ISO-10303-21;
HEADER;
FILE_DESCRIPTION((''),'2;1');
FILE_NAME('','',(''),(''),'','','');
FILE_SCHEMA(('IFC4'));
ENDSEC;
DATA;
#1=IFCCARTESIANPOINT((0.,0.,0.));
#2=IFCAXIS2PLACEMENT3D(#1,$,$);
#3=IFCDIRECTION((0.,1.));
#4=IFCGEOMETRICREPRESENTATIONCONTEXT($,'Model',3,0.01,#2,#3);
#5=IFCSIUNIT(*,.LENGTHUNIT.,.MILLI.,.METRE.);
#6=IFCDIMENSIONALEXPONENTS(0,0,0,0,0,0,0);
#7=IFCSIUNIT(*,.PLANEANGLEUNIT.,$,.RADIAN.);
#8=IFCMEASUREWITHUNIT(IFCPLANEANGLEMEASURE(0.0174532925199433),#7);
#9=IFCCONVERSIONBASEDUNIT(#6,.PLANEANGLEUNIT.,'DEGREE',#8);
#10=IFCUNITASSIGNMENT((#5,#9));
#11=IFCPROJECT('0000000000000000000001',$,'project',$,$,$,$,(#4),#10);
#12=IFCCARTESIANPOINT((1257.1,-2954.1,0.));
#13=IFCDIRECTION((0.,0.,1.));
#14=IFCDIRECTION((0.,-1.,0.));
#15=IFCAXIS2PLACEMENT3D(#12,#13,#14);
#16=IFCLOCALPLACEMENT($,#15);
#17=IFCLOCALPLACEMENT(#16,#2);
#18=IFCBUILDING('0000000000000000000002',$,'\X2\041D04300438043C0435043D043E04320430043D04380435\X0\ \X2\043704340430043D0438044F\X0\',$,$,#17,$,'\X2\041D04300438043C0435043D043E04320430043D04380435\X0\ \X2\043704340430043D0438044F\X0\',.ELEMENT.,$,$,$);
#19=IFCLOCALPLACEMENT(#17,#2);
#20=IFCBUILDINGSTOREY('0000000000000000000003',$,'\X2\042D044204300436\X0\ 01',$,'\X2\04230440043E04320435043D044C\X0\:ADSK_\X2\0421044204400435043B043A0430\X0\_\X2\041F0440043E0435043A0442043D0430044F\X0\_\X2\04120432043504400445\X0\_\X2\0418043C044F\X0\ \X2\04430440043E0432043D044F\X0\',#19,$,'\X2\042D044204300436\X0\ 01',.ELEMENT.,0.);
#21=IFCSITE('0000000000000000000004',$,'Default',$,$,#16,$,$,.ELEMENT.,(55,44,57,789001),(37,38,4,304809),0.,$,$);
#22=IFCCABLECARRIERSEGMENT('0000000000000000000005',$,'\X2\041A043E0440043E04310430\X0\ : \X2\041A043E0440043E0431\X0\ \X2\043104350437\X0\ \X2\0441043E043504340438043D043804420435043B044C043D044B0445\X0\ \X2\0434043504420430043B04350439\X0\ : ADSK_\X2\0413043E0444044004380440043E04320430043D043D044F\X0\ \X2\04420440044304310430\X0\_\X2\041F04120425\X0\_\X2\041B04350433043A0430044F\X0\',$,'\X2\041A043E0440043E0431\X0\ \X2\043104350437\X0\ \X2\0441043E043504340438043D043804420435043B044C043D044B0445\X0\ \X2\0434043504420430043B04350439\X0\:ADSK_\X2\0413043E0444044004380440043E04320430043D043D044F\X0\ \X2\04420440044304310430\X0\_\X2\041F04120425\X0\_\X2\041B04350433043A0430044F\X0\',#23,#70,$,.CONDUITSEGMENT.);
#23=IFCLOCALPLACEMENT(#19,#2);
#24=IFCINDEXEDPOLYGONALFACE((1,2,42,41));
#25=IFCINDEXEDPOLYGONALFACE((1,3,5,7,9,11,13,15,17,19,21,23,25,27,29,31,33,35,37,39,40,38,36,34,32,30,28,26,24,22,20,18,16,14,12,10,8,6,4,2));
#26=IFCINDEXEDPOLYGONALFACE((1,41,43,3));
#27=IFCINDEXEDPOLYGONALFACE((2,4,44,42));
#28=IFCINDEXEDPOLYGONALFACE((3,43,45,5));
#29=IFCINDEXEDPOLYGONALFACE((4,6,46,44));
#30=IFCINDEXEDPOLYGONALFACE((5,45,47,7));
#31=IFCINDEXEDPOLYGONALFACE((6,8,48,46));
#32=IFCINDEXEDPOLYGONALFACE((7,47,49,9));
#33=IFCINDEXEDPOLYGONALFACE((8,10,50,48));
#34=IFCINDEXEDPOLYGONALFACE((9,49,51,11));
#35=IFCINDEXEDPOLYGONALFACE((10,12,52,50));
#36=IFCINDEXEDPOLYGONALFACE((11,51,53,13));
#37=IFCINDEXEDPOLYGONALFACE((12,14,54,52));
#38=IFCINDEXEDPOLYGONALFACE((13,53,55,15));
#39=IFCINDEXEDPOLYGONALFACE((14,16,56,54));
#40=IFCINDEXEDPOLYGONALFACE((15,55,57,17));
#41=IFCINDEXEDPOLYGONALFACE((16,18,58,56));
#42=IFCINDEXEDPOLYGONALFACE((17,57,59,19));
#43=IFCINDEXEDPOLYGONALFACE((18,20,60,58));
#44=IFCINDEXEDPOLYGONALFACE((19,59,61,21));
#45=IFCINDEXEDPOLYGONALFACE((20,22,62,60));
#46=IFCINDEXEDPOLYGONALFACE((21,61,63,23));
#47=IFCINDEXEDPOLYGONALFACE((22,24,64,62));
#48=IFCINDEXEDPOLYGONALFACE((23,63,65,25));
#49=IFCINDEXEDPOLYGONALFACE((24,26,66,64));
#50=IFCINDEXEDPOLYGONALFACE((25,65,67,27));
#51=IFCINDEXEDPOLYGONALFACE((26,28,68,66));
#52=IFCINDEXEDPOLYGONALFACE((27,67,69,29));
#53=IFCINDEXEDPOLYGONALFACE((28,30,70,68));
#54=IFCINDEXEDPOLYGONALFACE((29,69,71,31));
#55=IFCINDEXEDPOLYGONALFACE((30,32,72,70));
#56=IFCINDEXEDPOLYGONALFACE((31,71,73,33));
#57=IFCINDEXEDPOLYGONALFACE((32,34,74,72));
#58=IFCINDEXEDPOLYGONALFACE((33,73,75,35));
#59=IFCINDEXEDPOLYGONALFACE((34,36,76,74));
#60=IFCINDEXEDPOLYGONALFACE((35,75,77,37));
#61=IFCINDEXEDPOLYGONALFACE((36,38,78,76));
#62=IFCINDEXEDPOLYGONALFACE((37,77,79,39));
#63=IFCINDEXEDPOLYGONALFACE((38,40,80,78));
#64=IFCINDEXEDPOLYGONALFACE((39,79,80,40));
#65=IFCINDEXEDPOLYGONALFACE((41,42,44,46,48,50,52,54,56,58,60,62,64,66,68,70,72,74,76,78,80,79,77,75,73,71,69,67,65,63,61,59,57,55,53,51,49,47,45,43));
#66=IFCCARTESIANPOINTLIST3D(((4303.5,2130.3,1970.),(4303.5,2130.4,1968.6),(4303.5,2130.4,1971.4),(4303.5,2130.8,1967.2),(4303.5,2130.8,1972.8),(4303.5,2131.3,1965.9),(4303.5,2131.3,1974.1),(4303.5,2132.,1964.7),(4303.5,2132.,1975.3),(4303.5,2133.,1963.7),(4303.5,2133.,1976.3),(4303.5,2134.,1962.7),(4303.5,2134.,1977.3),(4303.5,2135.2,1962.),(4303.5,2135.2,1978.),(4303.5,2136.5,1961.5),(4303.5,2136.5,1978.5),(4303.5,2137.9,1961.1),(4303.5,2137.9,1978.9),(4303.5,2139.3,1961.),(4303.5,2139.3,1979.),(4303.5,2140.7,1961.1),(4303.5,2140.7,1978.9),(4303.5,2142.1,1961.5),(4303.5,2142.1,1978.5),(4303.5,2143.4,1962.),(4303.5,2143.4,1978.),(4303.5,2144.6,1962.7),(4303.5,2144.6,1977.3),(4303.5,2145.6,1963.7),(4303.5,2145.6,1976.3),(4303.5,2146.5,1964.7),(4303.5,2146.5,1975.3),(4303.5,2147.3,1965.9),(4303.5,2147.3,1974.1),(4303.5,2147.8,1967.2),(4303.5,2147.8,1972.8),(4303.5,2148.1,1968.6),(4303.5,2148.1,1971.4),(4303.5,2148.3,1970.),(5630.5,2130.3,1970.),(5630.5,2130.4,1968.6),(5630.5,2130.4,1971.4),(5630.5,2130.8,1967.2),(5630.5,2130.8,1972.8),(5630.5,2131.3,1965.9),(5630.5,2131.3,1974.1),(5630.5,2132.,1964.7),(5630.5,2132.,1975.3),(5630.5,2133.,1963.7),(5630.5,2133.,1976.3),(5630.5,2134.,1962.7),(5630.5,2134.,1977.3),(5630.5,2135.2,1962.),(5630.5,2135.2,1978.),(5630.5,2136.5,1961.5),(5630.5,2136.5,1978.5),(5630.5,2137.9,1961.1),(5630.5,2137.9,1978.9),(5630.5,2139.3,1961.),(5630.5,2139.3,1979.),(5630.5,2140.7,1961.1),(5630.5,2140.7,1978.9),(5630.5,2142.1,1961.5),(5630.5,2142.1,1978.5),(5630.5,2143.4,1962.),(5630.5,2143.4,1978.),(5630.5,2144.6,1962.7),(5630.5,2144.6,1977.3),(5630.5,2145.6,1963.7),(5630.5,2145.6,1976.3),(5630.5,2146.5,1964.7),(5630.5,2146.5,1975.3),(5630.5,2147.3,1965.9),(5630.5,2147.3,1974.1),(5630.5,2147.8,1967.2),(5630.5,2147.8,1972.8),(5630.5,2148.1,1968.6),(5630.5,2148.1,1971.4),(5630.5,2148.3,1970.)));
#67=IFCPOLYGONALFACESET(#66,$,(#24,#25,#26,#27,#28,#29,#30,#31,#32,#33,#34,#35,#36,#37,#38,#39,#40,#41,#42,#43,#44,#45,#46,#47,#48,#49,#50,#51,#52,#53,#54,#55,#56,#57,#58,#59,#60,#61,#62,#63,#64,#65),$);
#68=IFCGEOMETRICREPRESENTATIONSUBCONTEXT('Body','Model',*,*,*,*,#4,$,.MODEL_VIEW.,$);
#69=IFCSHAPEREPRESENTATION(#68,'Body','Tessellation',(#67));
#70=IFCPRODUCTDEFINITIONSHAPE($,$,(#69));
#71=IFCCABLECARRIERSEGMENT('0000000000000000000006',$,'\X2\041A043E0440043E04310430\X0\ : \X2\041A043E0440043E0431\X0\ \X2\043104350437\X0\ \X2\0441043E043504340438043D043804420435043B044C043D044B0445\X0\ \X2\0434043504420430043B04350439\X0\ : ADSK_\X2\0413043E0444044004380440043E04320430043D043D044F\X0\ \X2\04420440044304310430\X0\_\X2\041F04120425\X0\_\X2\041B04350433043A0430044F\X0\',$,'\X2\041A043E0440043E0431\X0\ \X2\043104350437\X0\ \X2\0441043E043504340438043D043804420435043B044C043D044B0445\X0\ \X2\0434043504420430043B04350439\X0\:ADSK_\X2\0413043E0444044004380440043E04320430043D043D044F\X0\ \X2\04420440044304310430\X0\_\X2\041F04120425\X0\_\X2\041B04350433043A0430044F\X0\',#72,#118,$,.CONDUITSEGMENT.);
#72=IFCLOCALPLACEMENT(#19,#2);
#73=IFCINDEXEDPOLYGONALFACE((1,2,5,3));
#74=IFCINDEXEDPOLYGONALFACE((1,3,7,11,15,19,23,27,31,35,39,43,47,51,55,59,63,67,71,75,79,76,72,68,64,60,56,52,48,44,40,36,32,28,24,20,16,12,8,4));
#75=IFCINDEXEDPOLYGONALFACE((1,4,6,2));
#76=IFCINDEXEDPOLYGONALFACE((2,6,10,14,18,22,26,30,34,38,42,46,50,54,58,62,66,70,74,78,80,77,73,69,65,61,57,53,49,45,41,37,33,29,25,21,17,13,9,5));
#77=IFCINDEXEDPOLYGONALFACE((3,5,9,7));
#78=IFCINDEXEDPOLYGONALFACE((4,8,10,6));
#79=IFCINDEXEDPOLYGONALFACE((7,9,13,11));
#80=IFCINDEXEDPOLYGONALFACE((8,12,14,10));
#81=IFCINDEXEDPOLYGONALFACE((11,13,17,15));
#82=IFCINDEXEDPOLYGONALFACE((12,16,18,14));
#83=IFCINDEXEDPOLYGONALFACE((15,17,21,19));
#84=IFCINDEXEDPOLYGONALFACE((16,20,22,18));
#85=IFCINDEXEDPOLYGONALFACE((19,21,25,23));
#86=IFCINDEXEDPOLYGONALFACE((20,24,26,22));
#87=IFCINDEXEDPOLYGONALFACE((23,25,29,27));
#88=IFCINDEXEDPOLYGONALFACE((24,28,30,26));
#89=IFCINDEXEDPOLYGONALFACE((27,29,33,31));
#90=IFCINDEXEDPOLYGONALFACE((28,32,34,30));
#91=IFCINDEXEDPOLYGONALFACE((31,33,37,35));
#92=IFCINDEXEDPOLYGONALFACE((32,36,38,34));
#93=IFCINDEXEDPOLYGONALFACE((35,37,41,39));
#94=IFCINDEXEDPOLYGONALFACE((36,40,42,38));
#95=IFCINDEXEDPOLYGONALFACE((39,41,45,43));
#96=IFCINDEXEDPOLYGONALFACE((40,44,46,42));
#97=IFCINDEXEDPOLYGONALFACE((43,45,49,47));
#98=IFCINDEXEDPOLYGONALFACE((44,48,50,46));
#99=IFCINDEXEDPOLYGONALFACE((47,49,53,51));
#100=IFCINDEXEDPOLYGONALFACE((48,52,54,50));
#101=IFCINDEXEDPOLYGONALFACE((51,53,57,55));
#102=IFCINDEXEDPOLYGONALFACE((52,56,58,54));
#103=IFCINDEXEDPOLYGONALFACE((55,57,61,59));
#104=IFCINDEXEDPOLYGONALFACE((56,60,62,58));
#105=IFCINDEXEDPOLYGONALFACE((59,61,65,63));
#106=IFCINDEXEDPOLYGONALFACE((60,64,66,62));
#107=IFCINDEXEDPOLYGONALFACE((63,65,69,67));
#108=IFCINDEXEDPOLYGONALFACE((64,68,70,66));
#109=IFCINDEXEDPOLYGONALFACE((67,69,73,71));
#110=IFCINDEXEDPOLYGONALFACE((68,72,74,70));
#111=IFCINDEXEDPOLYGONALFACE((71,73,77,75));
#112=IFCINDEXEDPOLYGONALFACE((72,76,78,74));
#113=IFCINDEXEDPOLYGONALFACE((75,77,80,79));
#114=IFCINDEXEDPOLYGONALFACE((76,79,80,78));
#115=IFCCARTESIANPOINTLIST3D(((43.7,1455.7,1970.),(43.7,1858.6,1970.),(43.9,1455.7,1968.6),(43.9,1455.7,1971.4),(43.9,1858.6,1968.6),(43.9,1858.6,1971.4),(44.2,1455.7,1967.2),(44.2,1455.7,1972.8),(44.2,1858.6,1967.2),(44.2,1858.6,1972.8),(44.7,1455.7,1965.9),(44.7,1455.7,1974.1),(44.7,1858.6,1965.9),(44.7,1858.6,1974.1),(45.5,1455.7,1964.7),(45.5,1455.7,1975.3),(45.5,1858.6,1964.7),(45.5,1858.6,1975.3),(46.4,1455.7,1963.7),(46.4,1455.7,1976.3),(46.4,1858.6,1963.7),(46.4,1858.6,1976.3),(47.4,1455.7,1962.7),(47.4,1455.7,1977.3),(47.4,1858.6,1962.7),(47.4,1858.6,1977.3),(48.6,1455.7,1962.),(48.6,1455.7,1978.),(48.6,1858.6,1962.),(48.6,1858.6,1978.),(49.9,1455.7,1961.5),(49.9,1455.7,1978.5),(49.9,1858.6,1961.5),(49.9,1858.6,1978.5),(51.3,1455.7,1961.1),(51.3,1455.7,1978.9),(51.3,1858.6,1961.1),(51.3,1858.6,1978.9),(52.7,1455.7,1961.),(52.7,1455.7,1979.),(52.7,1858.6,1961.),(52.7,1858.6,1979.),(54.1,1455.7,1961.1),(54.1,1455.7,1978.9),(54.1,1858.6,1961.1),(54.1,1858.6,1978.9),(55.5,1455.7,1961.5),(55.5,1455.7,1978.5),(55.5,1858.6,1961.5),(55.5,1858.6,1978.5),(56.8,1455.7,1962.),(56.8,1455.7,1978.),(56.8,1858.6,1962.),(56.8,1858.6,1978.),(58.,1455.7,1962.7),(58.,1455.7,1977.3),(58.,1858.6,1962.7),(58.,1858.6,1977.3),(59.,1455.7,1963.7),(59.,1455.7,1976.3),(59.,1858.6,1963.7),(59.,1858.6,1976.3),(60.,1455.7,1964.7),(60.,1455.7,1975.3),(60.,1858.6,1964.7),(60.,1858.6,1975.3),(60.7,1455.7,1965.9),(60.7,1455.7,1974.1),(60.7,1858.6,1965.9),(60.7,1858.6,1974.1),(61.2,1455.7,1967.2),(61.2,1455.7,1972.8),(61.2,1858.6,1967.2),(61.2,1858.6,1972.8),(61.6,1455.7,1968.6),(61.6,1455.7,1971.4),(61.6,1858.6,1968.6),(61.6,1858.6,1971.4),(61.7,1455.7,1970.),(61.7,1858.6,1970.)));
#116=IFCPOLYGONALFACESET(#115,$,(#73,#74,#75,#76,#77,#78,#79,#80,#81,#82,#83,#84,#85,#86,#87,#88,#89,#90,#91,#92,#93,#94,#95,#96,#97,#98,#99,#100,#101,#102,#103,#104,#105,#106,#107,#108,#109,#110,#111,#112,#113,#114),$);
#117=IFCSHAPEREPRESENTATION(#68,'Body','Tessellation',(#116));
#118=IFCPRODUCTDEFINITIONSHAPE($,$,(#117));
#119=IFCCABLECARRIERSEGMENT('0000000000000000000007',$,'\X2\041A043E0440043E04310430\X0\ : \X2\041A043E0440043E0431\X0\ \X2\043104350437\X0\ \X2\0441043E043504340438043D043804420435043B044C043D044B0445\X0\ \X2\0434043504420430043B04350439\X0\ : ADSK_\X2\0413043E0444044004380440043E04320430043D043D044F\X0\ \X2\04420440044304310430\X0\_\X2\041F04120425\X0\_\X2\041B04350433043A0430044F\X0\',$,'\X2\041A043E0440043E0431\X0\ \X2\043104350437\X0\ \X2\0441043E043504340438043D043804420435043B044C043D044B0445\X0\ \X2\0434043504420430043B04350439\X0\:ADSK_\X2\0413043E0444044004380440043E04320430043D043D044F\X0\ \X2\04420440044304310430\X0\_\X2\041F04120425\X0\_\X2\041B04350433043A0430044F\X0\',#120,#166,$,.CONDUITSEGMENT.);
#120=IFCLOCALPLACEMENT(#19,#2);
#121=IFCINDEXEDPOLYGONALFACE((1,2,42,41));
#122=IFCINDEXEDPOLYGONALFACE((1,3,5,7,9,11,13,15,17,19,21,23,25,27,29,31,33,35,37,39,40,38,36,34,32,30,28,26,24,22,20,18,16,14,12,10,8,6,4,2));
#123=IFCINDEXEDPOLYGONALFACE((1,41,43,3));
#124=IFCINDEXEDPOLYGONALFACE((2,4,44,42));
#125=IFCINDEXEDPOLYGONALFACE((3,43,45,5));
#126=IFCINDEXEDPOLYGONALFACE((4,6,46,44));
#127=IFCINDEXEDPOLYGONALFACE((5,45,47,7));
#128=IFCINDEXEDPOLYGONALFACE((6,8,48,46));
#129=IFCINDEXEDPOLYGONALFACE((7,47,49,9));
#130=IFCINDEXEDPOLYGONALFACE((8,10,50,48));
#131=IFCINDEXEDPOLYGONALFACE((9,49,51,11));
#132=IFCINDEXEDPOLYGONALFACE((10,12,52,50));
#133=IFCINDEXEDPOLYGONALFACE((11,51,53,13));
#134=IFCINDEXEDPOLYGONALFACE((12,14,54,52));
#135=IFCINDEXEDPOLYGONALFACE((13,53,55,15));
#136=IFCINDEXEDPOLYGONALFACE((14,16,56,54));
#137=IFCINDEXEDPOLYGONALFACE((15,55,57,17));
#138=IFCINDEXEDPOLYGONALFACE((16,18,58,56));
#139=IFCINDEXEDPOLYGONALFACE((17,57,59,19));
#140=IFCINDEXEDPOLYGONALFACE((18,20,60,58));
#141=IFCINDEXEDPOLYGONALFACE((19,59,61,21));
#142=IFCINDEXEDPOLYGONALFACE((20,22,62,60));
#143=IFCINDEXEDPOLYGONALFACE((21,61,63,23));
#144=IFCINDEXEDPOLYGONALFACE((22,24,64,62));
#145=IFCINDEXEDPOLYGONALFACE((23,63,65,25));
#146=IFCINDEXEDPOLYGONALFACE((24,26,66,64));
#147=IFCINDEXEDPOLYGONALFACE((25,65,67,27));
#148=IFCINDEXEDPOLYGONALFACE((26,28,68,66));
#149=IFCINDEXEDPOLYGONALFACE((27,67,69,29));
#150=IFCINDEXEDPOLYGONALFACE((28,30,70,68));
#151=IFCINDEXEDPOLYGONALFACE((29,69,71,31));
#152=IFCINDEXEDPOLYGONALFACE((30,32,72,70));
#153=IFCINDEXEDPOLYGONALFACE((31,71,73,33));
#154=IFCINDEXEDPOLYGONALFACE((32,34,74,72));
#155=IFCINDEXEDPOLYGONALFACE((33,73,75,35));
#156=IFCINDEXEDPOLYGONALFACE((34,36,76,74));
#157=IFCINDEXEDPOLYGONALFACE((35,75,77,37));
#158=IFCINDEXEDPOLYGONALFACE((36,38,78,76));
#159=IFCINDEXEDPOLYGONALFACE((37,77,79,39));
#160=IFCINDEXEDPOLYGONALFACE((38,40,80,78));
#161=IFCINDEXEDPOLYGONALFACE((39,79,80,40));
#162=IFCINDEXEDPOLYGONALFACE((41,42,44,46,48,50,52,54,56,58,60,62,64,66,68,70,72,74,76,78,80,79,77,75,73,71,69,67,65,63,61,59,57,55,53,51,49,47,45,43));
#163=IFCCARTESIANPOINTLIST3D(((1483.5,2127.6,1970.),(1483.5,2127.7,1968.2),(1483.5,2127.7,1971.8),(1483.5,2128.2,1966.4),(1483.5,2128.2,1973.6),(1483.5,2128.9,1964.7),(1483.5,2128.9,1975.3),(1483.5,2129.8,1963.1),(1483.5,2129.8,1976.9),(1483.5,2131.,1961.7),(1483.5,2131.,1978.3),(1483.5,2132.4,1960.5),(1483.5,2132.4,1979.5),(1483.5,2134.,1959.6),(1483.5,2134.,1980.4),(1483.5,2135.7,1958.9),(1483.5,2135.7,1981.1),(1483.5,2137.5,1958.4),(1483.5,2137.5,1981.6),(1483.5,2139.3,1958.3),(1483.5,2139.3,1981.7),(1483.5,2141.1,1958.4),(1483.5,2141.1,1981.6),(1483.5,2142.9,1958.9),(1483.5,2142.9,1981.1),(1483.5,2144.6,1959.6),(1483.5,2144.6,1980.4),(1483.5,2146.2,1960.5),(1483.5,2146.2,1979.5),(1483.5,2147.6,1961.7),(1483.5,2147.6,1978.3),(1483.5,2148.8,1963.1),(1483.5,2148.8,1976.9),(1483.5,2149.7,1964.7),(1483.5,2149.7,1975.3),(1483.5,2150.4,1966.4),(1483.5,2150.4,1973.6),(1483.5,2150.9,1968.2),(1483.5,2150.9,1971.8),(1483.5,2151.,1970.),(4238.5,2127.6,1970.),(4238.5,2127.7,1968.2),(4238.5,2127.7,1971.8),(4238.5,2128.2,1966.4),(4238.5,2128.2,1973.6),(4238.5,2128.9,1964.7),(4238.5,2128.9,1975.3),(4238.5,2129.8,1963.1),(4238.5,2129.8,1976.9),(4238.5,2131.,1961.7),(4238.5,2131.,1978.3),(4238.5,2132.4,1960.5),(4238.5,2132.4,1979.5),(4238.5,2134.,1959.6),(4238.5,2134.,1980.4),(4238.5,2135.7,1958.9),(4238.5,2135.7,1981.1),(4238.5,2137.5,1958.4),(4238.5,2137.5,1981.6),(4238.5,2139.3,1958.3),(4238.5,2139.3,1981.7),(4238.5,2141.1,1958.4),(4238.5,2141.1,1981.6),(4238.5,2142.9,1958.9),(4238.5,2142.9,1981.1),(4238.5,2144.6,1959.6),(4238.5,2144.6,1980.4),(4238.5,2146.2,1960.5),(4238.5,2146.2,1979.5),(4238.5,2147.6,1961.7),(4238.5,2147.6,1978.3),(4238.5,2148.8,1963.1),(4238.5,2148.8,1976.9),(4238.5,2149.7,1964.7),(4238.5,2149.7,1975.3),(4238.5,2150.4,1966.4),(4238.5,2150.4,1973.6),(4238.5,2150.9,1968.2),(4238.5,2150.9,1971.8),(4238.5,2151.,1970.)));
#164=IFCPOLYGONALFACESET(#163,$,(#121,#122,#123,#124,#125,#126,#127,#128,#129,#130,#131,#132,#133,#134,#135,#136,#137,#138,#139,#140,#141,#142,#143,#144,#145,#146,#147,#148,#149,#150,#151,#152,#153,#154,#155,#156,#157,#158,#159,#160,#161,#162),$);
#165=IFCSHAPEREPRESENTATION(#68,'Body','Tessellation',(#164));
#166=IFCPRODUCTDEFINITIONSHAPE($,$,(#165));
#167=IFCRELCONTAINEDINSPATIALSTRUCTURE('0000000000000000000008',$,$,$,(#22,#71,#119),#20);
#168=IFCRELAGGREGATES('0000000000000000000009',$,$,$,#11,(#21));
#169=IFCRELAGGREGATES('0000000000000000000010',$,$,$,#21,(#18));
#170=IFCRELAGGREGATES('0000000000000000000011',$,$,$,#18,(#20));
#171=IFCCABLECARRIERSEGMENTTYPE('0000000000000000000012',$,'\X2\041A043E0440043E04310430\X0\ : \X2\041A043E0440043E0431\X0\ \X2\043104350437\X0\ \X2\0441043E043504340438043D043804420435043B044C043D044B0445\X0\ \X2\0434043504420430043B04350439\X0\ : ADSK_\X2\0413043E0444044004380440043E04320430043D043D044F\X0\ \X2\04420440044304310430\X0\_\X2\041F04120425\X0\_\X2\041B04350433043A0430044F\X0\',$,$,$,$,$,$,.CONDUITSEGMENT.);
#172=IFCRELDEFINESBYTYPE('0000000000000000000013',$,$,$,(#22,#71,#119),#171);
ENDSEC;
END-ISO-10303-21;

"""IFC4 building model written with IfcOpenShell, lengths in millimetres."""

from ifc_helpers import new_model, entity, si_unit, converted_unit, direction, frame, origin, place, context, subcontext, project, spatial, indexed_curve, outline, extrude, type_object, element, save


model = new_model("IFC4")

# Units and contexts
model_context = context("Model", 3, precision=0.01, world=origin(), true_north=direction((0.0, 1.0)))
body_context = subcontext(model_context, "Body", "Model", "MODEL_VIEW")
ifc_project = project(units=[si_unit("LENGTHUNIT", "METRE", prefix="MILLI"), converted_unit("PLANEANGLEUNIT", "DEGREE", entity("IfcPlaneAngleMeasure", 0.0174532925199433), si_unit("PLANEANGLEUNIT", "RADIAN"), dimensions=[0, 0, 0, 0, 0, 0, 0])], contexts=[model_context])

# Site, building, storey
site_placement = place(None, frame((1257.1, -2954.1, 0.0), z_axis=(0.0, 0.0, 1.0), x_axis=(0.0, -1.0, 0.0)))
site = spatial("IfcSite", under=ifc_project, at=site_placement, Name="Default", CompositionType="ELEMENT", RefLatitude=(55, 44, 57, 789001), RefLongitude=(37, 38, 4, 304809), RefElevation=0.0)
building_placement = place(site_placement, origin())
building = spatial("IfcBuilding", under=site, at=building_placement, Name="Наименование здания", LongName="Наименование здания", CompositionType="ELEMENT")
storey_placement = place(building_placement, origin())
storey = spatial("IfcBuildingStorey", under=building, at=storey_placement, Name="Этаж 01", ObjectType="Уровень:ADSK_Стрелка_Проектная_Вверх_Имя уровня", LongName="Этаж 01", CompositionType="ELEMENT", Elevation=0.0)

# Cable carrier segments
cable_carrier_segment_type = type_object("IfcCableCarrierSegmentType", Name="Короба : Короб без соединительных деталей : ADSK_Гофрировання труба_ПВХ_Легкая", PredefinedType="CONDUITSEGMENT")
cable_carrier_segment_1_placement = place(storey_placement, origin())
element("IfcCableCarrierSegment", 1, at=cable_carrier_segment_1_placement, inside=storey, type_object=cable_carrier_segment_type, Name="Короба : Короб без соединительных деталей : ADSK_Гофрировання труба_ПВХ_Легкая", ObjectType="Короб без соединительных деталей:ADSK_Гофрировання труба_ПВХ_Легкая", PredefinedType="CONDUITSEGMENT", context=body_context, shape_type="SweptSolid", body=[
    extrude(outline(indexed_curve([(9.0, 0.0), (8.9, 1.4), (8.5, 2.8), (8.0, 4.1), (7.3, 5.3), (6.3, 6.3), (5.3, 7.3), (4.1, 8.0), (2.8, 8.5), (1.4, 8.9), (0.0, 9.0), (-1.4, 8.9), (-2.8, 8.5), (-4.1, 8.0), (-5.3, 7.3), (-6.3, 6.3), (-7.3, 5.3), (-8.0, 4.1), (-8.5, 2.8), (-8.9, 1.4), (-9.0, 0.0), (-8.9, -1.4), (-8.5, -2.8), (-8.0, -4.1), (-7.3, -5.3), (-6.3, -6.3), (-5.3, -7.3), (-4.1, -8.0), (-2.8, -8.5), (-1.4, -8.9), (0.0, -9.0), (1.4, -8.9), (2.8, -8.5), (4.1, -8.0), (5.3, -7.3), (6.3, -6.3), (7.3, -5.3), (8.0, -4.1), (8.5, -2.8), (8.9, -1.4), (9.0, 0.0)], self_intersect=False)), frame((4303.5, 2139.3, 1970.0), z_axis=(1.0, 0.0, 0.0), x_axis=(0.0, 1.0, 0.0)), (0.0, 0.0, 1.0), 1327.0),
])
cable_carrier_segment_2_placement = place(storey_placement, origin())
element("IfcCableCarrierSegment", 2, at=cable_carrier_segment_2_placement, inside=storey, type_object=cable_carrier_segment_type, Name="Короба : Короб без соединительных деталей : ADSK_Гофрировання труба_ПВХ_Легкая", ObjectType="Короб без соединительных деталей:ADSK_Гофрировання труба_ПВХ_Легкая", PredefinedType="CONDUITSEGMENT", context=body_context, shape_type="SweptSolid", body=[
    extrude(outline(indexed_curve([(9.0, 0.0), (8.9, 1.4), (8.5, 2.8), (8.0, 4.1), (7.3, 5.3), (6.3, 6.3), (5.3, 7.3), (4.1, 8.0), (2.8, 8.5), (1.4, 8.9), (0.0, 9.0), (-1.4, 8.9), (-2.8, 8.5), (-4.1, 8.0), (-5.3, 7.3), (-6.3, 6.3), (-7.3, 5.3), (-8.0, 4.1), (-8.5, 2.8), (-8.9, 1.4), (-9.0, 0.0), (-8.9, -1.4), (-8.5, -2.8), (-8.0, -4.1), (-7.3, -5.3), (-6.3, -6.3), (-5.3, -7.3), (-4.1, -8.0), (-2.8, -8.5), (-1.4, -8.9), (0.0, -9.0), (1.4, -8.9), (2.8, -8.5), (4.1, -8.0), (5.3, -7.3), (6.3, -6.3), (7.3, -5.3), (8.0, -4.1), (8.5, -2.8), (8.9, -1.4), (9.0, 0.0)], self_intersect=False)), frame((52.7, 1455.7, 1970.0), z_axis=(0.0, 1.0, 0.0), x_axis=(1.0, 0.0, 0.0)), (0.0, 0.0, 1.0), 402.9),
])
cable_carrier_segment_3_placement = place(storey_placement, origin())
element("IfcCableCarrierSegment", 3, at=cable_carrier_segment_3_placement, inside=storey, type_object=cable_carrier_segment_type, Name="Короба : Короб без соединительных деталей : ADSK_Гофрировання труба_ПВХ_Легкая", ObjectType="Короб без соединительных деталей:ADSK_Гофрировання труба_ПВХ_Легкая", PredefinedType="CONDUITSEGMENT", context=body_context, shape_type="SweptSolid", body=[
    extrude(outline(indexed_curve([(11.7, 0.0), (11.6, 1.8), (11.1, 3.6), (10.4, 5.3), (9.5, 6.9), (8.3, 8.3), (6.9, 9.5), (5.3, 10.4), (3.6, 11.1), (1.8, 11.6), (0.0, 11.7), (-1.8, 11.6), (-3.6, 11.1), (-5.3, 10.4), (-6.9, 9.5), (-8.3, 8.3), (-9.5, 6.9), (-10.4, 5.3), (-11.1, 3.6), (-11.6, 1.8), (-11.7, 0.0), (-11.6, -1.8), (-11.1, -3.6), (-10.4, -5.3), (-9.5, -6.9), (-8.3, -8.3), (-6.9, -9.5), (-5.3, -10.4), (-3.6, -11.1), (-1.8, -11.6), (0.0, -11.7), (1.8, -11.6), (3.6, -11.1), (5.3, -10.4), (6.9, -9.5), (8.3, -8.3), (9.5, -6.9), (10.4, -5.3), (11.1, -3.6), (11.6, -1.8), (11.7, 0.0)], self_intersect=False)), frame((1483.5, 2139.3, 1970.0), z_axis=(1.0, 0.0, 0.0), x_axis=(0.0, -1.0, 0.0)), (0.0, 0.0, 1.0), 2755.0),
])

save(model, "model.ifc")
